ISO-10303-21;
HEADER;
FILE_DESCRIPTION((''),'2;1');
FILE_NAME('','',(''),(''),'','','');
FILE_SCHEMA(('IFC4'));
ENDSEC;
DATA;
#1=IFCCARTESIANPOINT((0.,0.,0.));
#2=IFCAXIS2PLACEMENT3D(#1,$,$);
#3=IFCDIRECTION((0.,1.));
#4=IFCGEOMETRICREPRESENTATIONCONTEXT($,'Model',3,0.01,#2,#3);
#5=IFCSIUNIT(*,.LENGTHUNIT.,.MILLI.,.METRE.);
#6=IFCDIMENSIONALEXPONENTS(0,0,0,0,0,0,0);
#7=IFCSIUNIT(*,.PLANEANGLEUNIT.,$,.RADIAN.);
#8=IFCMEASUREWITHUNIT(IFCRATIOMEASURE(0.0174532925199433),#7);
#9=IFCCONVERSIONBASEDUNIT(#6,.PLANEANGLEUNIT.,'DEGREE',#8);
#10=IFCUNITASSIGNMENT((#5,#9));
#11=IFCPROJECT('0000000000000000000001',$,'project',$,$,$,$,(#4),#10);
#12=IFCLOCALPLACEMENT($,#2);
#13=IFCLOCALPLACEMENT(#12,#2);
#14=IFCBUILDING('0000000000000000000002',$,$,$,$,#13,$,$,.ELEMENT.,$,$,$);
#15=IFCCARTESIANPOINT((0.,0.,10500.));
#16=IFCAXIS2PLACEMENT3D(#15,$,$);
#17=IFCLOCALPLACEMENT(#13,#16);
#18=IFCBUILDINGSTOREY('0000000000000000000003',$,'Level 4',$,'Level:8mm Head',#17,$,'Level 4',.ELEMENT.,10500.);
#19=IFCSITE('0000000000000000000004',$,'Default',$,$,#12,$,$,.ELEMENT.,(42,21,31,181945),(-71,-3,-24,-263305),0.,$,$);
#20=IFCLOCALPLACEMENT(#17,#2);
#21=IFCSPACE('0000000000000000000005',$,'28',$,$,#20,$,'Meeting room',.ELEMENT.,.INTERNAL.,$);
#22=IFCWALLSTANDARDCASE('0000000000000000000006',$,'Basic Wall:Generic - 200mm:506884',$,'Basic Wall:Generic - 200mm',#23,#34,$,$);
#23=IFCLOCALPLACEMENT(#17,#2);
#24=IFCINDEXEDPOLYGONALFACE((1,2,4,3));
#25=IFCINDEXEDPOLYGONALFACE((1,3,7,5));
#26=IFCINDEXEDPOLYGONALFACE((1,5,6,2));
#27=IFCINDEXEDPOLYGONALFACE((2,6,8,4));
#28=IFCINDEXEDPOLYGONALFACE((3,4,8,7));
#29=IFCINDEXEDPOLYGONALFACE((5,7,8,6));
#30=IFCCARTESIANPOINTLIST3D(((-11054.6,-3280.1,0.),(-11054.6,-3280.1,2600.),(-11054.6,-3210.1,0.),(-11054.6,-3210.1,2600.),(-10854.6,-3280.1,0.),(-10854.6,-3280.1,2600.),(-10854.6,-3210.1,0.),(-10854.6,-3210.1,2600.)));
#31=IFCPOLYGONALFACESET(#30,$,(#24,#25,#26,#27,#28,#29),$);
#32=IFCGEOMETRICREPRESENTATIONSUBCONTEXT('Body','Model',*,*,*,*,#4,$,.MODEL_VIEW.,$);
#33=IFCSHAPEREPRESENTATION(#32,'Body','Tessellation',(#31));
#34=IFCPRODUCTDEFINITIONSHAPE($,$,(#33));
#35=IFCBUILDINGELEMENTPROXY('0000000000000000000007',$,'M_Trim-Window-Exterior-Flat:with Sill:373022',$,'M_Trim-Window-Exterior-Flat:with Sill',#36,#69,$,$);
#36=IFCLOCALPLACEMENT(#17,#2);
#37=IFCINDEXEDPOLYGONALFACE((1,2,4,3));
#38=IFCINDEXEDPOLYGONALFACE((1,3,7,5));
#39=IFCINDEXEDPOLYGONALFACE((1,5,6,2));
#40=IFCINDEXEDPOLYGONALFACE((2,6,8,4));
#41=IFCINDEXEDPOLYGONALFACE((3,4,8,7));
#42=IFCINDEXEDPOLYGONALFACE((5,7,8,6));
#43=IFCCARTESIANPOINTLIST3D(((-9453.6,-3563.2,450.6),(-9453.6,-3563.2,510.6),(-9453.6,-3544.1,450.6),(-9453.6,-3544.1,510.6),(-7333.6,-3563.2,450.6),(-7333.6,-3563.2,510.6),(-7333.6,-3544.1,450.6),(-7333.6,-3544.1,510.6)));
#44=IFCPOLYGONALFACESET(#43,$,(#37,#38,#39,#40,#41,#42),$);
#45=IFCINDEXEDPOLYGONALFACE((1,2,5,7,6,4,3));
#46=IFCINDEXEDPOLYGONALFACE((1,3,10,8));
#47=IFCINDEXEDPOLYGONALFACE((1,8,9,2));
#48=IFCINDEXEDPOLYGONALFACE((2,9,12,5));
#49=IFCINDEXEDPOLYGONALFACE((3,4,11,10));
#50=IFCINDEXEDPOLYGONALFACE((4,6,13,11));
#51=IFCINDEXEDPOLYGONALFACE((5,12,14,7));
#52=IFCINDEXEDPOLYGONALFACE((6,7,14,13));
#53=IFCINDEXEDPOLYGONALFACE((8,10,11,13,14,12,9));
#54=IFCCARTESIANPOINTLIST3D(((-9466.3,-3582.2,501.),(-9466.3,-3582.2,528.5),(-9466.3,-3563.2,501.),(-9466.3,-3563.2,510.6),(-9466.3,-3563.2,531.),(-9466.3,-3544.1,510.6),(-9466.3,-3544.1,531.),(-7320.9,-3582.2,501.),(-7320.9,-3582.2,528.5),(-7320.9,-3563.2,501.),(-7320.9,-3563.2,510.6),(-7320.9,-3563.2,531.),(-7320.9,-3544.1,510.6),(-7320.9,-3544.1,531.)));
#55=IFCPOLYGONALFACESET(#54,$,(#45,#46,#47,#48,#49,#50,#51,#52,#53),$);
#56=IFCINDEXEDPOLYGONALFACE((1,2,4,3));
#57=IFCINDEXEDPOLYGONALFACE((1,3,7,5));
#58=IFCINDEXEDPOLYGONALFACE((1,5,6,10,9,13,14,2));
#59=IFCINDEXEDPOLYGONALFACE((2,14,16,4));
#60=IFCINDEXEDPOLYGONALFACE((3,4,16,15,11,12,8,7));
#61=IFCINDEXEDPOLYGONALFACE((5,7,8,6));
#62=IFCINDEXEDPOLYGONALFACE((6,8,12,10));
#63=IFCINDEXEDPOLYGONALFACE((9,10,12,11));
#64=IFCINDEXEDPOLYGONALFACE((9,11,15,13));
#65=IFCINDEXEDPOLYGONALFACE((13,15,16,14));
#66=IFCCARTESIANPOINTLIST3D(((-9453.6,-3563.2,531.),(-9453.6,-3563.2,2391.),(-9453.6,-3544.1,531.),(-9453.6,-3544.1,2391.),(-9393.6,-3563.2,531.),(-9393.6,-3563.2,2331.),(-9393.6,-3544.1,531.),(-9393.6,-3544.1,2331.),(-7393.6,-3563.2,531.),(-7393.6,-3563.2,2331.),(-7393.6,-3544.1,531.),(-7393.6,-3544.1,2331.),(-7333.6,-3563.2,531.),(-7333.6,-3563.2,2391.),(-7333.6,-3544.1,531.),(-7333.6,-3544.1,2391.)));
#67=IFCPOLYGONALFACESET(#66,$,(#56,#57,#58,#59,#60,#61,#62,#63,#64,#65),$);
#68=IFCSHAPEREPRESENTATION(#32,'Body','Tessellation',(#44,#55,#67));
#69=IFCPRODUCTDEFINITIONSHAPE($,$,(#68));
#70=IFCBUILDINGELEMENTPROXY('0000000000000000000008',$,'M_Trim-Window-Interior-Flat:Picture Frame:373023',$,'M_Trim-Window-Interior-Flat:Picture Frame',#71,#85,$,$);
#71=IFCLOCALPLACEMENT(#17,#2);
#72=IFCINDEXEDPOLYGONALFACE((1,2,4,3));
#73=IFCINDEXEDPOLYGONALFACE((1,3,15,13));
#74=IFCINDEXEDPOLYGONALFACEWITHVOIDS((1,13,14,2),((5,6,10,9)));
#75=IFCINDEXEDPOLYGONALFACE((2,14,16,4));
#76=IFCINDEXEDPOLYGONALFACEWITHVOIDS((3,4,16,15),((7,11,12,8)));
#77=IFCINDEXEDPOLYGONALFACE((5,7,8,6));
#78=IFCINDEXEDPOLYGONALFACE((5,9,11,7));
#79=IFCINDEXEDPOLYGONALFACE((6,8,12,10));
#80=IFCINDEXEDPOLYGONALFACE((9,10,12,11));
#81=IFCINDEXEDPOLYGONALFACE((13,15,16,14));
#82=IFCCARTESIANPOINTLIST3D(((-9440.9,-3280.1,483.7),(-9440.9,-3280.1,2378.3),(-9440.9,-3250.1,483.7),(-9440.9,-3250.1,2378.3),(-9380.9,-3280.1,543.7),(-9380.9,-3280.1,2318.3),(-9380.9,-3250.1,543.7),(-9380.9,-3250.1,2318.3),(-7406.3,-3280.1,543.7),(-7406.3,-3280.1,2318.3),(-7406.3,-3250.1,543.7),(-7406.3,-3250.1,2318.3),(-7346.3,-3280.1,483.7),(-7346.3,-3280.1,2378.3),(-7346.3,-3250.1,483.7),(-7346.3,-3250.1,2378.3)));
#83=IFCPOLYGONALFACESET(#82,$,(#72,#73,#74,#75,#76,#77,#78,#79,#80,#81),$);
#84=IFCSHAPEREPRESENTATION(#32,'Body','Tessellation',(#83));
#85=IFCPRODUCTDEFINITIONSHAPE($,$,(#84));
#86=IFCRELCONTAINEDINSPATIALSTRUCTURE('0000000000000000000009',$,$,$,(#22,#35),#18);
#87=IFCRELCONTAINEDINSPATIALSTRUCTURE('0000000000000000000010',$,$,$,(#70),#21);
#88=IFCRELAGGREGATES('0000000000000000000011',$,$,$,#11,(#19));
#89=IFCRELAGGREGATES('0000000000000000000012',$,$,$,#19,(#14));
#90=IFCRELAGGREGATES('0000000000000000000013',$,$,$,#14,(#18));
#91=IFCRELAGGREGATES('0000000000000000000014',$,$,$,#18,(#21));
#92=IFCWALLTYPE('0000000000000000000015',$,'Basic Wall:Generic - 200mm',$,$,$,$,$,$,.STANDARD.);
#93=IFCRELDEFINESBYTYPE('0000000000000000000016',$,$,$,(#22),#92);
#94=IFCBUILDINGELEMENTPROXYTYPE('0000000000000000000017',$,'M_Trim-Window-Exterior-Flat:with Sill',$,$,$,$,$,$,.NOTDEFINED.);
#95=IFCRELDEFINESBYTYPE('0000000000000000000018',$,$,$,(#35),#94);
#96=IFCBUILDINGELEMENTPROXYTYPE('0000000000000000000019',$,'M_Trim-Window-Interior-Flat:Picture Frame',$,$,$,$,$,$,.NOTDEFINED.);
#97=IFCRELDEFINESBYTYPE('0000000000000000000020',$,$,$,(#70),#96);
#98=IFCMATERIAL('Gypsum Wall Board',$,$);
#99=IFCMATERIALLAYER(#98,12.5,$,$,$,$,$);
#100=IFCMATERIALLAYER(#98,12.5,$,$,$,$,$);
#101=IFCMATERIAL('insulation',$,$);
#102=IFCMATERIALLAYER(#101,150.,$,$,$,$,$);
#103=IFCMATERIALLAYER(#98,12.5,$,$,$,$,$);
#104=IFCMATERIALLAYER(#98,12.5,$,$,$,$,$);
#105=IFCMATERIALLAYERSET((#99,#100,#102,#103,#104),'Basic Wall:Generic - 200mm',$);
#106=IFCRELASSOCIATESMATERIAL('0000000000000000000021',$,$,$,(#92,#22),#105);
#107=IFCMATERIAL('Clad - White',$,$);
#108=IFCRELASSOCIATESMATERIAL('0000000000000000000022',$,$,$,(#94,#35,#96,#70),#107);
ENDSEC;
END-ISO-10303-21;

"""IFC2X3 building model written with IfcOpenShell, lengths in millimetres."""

from ifc_helpers import new_model, entity, si_unit, converted_unit, direction, frame, frame_2d, origin, place, context, subcontext, project, spatial, polyline, rectangle, outline, extrude, source, transform, mapped, material, layer, layer_set, layer_usage, type_object, type_shapes, element, save


model = new_model("IFC2X3")

# Units and contexts
model_context = context("Model", 3, precision=0.01, world=origin(), true_north=direction((0.0, 1.0)))
body_context = subcontext(model_context, "Body", "Model", "MODEL_VIEW")
ifc_project = project(units=[si_unit("LENGTHUNIT", "METRE", prefix="MILLI"), converted_unit("PLANEANGLEUNIT", "DEGREE", entity("IfcRatioMeasure", 0.0174532925199433), si_unit("PLANEANGLEUNIT", "RADIAN"), dimensions=[0, 0, 0, 0, 0, 0, 0])], contexts=[model_context])

# Site, building, storey
site_placement = place(None, frame((0.0, 0.0, 0.0)))
site = spatial("IfcSite", under=ifc_project, at=site_placement, Name="Default", CompositionType="ELEMENT", RefLatitude=(42, 21, 31, 181945), RefLongitude=(-71, -3, -24, -263305), RefElevation=0.0)
building_placement = place(site_placement, origin())
building = spatial("IfcBuilding", under=site, at=building_placement, CompositionType="ELEMENT")
storey_placement = place(building_placement, frame((0.0, 0.0, 10500.0)))
storey = spatial("IfcBuildingStorey", under=building, at=storey_placement, Name="Level 4", ObjectType="Level:8mm Head", LongName="Level 4", CompositionType="ELEMENT", Elevation=10500.0)

# Wall
ifc_material_1 = material(Name="Gypsum Wall Board")
ifc_layer_1 = layer(ifc_material_1, 12.5)
ifc_layer_2 = layer(ifc_material_1, 12.5)
ifc_material_2 = material(Name="insulation")
ifc_layer_3 = layer(ifc_material_2, 150.0)
ifc_layer_4 = layer(ifc_material_1, 12.5)
ifc_layer_5 = layer(ifc_material_1, 12.5)
ifc_layer_set = layer_set([ifc_layer_1, ifc_layer_2, ifc_layer_3, ifc_layer_4, ifc_layer_5], Name="Basic Wall:Generic - 200mm")
wall_type = type_object("IfcWallType", Name="Basic Wall:Generic - 200mm", PredefinedType="STANDARD", material=ifc_layer_set)
ifc_layer_usage_1 = layer_usage(ifc_layer_set, "AXIS2", "NEGATIVE", 100.0)
wall_1_placement = place(storey_placement, frame((-10954.6, -3210.1, 0.0), z_axis=(0.0, 0.0, 1.0), x_axis=(0.0, -1.0, 0.0)))
element("IfcWallStandardCase", 1, at=wall_1_placement, inside=storey, type_object=wall_type, material=ifc_layer_usage_1, Name="Basic Wall:Generic - 200mm:506884", ObjectType="Basic Wall:Generic - 200mm", context=body_context, shape_type="SweptSolid", body=[
    extrude(rectangle(XDim=70.0, YDim=200.0, at=frame_2d((35.0, 0.0), x_axis=(-1.0, 0.0))), origin(), (0.0, 0.0, 1.0), 2600.0),
])

# Building element proxy
ifc_material_3 = material(Name="Clad - White")
building_element_proxy_type_1 = type_object("IfcBuildingElementProxyType", Name="M_Trim-Window-Exterior-Flat:with Sill", PredefinedType="NOTDEFINED", material=ifc_material_3)
shared_shape_1 = source(origin(), body_context, "Body", "SweptSolid", [
    extrude(rectangle(XDim=2120.0, YDim=60.0, at=frame_2d((0.0, 0.0), x_axis=(1.0, 0.0))), frame((0.0, -1850.4, 0.0), z_axis=(0.0, 0.0, 1.0), x_axis=(-1.0, 0.0, 0.0)), (0.0, 0.0, 1.0), 19.1),
    extrude(outline(polyline([(-19.0, -15.2), (0.0, -15.2), (0.0, -5.7), (19.0, -5.7), (19.0, 14.8), (0.0, 14.8), (-19.0, 12.3), (-19.0, -15.2)])), frame((-1072.7, -1814.8, 19.0), z_axis=(1.0, 0.0, 0.0), x_axis=(0.0, 0.0, -1.0)), (0.0, 0.0, 1.0), 2145.4),
    extrude(outline(polyline([(-945.0, -1060.0), (915.0, -1060.0), (915.0, -1000.0), (-885.0, -1000.0), (-885.0, 1000.0), (915.0, 1000.0), (915.0, 1060.0), (-945.0, 1060.0), (-945.0, -1060.0)])), frame((0.0, -885.0, 0.0), z_axis=(0.0, 0.0, 1.0), x_axis=(0.0, -1.0, 0.0)), (0.0, 0.0, 1.0), 19.1),
])
type_shapes(building_element_proxy_type_1, [shared_shape_1])
proxy_1_placement = place(storey_placement, frame((-8393.6, -3544.1, 2331.0), z_axis=(0.0, -1.0, 0.0), x_axis=(1.0, 0.0, 0.0)))
element("IfcBuildingElementProxy", 2, at=proxy_1_placement, inside=storey, type_object=building_element_proxy_type_1, material=ifc_material_3, Name="M_Trim-Window-Exterior-Flat:with Sill:373022", ObjectType="M_Trim-Window-Exterior-Flat:with Sill", context=body_context, shape_type="MappedRepresentation", body=[
    mapped(shared_shape_1, transform((0.0, 0.0, 0.0), scale=1.0)),
])

# Shared definitions
space_placement = place(storey_placement, origin())
space = spatial("IfcSpace", under=storey, at=space_placement, Name="28", LongName="Meeting room", CompositionType="ELEMENT", InteriorOrExteriorSpace="INTERNAL")

# Building element proxy
building_element_proxy_type_2 = type_object("IfcBuildingElementProxyType", Name="M_Trim-Window-Interior-Flat:Picture Frame", PredefinedType="NOTDEFINED", material=ifc_material_3)
shared_shape_2 = source(origin(), body_context, "Body", "SweptSolid", [
    extrude(outline(polyline([(-1047.3, -947.3), (1047.3, -947.3), (1047.3, 947.3), (-1047.3, 947.3), (-1047.3, -947.3)]), holes=[polyline([(-987.3, -887.3), (-987.3, 887.3), (987.3, 887.3), (987.3, -887.3), (-987.3, -887.3)])]), frame((0.0, -900.0, 0.0), z_axis=(0.0, 0.0, 1.0), x_axis=(-1.0, 0.0, 0.0)), (0.0, 0.0, 1.0), 30.0),
])
type_shapes(building_element_proxy_type_2, [shared_shape_2])
proxy_2_placement = place(space_placement, frame((-8393.6, -3280.1, 2331.0), z_axis=(0.0, 1.0, 0.0), x_axis=(-1.0, 0.0, 0.0)))
element("IfcBuildingElementProxy", 3, at=proxy_2_placement, inside=space, type_object=building_element_proxy_type_2, material=ifc_material_3, Name="M_Trim-Window-Interior-Flat:Picture Frame:373023", ObjectType="M_Trim-Window-Interior-Flat:Picture Frame", context=body_context, shape_type="MappedRepresentation", body=[
    mapped(shared_shape_2, transform((0.0, 0.0, 0.0), scale=1.0)),
])

save(model, "model.ifc")
